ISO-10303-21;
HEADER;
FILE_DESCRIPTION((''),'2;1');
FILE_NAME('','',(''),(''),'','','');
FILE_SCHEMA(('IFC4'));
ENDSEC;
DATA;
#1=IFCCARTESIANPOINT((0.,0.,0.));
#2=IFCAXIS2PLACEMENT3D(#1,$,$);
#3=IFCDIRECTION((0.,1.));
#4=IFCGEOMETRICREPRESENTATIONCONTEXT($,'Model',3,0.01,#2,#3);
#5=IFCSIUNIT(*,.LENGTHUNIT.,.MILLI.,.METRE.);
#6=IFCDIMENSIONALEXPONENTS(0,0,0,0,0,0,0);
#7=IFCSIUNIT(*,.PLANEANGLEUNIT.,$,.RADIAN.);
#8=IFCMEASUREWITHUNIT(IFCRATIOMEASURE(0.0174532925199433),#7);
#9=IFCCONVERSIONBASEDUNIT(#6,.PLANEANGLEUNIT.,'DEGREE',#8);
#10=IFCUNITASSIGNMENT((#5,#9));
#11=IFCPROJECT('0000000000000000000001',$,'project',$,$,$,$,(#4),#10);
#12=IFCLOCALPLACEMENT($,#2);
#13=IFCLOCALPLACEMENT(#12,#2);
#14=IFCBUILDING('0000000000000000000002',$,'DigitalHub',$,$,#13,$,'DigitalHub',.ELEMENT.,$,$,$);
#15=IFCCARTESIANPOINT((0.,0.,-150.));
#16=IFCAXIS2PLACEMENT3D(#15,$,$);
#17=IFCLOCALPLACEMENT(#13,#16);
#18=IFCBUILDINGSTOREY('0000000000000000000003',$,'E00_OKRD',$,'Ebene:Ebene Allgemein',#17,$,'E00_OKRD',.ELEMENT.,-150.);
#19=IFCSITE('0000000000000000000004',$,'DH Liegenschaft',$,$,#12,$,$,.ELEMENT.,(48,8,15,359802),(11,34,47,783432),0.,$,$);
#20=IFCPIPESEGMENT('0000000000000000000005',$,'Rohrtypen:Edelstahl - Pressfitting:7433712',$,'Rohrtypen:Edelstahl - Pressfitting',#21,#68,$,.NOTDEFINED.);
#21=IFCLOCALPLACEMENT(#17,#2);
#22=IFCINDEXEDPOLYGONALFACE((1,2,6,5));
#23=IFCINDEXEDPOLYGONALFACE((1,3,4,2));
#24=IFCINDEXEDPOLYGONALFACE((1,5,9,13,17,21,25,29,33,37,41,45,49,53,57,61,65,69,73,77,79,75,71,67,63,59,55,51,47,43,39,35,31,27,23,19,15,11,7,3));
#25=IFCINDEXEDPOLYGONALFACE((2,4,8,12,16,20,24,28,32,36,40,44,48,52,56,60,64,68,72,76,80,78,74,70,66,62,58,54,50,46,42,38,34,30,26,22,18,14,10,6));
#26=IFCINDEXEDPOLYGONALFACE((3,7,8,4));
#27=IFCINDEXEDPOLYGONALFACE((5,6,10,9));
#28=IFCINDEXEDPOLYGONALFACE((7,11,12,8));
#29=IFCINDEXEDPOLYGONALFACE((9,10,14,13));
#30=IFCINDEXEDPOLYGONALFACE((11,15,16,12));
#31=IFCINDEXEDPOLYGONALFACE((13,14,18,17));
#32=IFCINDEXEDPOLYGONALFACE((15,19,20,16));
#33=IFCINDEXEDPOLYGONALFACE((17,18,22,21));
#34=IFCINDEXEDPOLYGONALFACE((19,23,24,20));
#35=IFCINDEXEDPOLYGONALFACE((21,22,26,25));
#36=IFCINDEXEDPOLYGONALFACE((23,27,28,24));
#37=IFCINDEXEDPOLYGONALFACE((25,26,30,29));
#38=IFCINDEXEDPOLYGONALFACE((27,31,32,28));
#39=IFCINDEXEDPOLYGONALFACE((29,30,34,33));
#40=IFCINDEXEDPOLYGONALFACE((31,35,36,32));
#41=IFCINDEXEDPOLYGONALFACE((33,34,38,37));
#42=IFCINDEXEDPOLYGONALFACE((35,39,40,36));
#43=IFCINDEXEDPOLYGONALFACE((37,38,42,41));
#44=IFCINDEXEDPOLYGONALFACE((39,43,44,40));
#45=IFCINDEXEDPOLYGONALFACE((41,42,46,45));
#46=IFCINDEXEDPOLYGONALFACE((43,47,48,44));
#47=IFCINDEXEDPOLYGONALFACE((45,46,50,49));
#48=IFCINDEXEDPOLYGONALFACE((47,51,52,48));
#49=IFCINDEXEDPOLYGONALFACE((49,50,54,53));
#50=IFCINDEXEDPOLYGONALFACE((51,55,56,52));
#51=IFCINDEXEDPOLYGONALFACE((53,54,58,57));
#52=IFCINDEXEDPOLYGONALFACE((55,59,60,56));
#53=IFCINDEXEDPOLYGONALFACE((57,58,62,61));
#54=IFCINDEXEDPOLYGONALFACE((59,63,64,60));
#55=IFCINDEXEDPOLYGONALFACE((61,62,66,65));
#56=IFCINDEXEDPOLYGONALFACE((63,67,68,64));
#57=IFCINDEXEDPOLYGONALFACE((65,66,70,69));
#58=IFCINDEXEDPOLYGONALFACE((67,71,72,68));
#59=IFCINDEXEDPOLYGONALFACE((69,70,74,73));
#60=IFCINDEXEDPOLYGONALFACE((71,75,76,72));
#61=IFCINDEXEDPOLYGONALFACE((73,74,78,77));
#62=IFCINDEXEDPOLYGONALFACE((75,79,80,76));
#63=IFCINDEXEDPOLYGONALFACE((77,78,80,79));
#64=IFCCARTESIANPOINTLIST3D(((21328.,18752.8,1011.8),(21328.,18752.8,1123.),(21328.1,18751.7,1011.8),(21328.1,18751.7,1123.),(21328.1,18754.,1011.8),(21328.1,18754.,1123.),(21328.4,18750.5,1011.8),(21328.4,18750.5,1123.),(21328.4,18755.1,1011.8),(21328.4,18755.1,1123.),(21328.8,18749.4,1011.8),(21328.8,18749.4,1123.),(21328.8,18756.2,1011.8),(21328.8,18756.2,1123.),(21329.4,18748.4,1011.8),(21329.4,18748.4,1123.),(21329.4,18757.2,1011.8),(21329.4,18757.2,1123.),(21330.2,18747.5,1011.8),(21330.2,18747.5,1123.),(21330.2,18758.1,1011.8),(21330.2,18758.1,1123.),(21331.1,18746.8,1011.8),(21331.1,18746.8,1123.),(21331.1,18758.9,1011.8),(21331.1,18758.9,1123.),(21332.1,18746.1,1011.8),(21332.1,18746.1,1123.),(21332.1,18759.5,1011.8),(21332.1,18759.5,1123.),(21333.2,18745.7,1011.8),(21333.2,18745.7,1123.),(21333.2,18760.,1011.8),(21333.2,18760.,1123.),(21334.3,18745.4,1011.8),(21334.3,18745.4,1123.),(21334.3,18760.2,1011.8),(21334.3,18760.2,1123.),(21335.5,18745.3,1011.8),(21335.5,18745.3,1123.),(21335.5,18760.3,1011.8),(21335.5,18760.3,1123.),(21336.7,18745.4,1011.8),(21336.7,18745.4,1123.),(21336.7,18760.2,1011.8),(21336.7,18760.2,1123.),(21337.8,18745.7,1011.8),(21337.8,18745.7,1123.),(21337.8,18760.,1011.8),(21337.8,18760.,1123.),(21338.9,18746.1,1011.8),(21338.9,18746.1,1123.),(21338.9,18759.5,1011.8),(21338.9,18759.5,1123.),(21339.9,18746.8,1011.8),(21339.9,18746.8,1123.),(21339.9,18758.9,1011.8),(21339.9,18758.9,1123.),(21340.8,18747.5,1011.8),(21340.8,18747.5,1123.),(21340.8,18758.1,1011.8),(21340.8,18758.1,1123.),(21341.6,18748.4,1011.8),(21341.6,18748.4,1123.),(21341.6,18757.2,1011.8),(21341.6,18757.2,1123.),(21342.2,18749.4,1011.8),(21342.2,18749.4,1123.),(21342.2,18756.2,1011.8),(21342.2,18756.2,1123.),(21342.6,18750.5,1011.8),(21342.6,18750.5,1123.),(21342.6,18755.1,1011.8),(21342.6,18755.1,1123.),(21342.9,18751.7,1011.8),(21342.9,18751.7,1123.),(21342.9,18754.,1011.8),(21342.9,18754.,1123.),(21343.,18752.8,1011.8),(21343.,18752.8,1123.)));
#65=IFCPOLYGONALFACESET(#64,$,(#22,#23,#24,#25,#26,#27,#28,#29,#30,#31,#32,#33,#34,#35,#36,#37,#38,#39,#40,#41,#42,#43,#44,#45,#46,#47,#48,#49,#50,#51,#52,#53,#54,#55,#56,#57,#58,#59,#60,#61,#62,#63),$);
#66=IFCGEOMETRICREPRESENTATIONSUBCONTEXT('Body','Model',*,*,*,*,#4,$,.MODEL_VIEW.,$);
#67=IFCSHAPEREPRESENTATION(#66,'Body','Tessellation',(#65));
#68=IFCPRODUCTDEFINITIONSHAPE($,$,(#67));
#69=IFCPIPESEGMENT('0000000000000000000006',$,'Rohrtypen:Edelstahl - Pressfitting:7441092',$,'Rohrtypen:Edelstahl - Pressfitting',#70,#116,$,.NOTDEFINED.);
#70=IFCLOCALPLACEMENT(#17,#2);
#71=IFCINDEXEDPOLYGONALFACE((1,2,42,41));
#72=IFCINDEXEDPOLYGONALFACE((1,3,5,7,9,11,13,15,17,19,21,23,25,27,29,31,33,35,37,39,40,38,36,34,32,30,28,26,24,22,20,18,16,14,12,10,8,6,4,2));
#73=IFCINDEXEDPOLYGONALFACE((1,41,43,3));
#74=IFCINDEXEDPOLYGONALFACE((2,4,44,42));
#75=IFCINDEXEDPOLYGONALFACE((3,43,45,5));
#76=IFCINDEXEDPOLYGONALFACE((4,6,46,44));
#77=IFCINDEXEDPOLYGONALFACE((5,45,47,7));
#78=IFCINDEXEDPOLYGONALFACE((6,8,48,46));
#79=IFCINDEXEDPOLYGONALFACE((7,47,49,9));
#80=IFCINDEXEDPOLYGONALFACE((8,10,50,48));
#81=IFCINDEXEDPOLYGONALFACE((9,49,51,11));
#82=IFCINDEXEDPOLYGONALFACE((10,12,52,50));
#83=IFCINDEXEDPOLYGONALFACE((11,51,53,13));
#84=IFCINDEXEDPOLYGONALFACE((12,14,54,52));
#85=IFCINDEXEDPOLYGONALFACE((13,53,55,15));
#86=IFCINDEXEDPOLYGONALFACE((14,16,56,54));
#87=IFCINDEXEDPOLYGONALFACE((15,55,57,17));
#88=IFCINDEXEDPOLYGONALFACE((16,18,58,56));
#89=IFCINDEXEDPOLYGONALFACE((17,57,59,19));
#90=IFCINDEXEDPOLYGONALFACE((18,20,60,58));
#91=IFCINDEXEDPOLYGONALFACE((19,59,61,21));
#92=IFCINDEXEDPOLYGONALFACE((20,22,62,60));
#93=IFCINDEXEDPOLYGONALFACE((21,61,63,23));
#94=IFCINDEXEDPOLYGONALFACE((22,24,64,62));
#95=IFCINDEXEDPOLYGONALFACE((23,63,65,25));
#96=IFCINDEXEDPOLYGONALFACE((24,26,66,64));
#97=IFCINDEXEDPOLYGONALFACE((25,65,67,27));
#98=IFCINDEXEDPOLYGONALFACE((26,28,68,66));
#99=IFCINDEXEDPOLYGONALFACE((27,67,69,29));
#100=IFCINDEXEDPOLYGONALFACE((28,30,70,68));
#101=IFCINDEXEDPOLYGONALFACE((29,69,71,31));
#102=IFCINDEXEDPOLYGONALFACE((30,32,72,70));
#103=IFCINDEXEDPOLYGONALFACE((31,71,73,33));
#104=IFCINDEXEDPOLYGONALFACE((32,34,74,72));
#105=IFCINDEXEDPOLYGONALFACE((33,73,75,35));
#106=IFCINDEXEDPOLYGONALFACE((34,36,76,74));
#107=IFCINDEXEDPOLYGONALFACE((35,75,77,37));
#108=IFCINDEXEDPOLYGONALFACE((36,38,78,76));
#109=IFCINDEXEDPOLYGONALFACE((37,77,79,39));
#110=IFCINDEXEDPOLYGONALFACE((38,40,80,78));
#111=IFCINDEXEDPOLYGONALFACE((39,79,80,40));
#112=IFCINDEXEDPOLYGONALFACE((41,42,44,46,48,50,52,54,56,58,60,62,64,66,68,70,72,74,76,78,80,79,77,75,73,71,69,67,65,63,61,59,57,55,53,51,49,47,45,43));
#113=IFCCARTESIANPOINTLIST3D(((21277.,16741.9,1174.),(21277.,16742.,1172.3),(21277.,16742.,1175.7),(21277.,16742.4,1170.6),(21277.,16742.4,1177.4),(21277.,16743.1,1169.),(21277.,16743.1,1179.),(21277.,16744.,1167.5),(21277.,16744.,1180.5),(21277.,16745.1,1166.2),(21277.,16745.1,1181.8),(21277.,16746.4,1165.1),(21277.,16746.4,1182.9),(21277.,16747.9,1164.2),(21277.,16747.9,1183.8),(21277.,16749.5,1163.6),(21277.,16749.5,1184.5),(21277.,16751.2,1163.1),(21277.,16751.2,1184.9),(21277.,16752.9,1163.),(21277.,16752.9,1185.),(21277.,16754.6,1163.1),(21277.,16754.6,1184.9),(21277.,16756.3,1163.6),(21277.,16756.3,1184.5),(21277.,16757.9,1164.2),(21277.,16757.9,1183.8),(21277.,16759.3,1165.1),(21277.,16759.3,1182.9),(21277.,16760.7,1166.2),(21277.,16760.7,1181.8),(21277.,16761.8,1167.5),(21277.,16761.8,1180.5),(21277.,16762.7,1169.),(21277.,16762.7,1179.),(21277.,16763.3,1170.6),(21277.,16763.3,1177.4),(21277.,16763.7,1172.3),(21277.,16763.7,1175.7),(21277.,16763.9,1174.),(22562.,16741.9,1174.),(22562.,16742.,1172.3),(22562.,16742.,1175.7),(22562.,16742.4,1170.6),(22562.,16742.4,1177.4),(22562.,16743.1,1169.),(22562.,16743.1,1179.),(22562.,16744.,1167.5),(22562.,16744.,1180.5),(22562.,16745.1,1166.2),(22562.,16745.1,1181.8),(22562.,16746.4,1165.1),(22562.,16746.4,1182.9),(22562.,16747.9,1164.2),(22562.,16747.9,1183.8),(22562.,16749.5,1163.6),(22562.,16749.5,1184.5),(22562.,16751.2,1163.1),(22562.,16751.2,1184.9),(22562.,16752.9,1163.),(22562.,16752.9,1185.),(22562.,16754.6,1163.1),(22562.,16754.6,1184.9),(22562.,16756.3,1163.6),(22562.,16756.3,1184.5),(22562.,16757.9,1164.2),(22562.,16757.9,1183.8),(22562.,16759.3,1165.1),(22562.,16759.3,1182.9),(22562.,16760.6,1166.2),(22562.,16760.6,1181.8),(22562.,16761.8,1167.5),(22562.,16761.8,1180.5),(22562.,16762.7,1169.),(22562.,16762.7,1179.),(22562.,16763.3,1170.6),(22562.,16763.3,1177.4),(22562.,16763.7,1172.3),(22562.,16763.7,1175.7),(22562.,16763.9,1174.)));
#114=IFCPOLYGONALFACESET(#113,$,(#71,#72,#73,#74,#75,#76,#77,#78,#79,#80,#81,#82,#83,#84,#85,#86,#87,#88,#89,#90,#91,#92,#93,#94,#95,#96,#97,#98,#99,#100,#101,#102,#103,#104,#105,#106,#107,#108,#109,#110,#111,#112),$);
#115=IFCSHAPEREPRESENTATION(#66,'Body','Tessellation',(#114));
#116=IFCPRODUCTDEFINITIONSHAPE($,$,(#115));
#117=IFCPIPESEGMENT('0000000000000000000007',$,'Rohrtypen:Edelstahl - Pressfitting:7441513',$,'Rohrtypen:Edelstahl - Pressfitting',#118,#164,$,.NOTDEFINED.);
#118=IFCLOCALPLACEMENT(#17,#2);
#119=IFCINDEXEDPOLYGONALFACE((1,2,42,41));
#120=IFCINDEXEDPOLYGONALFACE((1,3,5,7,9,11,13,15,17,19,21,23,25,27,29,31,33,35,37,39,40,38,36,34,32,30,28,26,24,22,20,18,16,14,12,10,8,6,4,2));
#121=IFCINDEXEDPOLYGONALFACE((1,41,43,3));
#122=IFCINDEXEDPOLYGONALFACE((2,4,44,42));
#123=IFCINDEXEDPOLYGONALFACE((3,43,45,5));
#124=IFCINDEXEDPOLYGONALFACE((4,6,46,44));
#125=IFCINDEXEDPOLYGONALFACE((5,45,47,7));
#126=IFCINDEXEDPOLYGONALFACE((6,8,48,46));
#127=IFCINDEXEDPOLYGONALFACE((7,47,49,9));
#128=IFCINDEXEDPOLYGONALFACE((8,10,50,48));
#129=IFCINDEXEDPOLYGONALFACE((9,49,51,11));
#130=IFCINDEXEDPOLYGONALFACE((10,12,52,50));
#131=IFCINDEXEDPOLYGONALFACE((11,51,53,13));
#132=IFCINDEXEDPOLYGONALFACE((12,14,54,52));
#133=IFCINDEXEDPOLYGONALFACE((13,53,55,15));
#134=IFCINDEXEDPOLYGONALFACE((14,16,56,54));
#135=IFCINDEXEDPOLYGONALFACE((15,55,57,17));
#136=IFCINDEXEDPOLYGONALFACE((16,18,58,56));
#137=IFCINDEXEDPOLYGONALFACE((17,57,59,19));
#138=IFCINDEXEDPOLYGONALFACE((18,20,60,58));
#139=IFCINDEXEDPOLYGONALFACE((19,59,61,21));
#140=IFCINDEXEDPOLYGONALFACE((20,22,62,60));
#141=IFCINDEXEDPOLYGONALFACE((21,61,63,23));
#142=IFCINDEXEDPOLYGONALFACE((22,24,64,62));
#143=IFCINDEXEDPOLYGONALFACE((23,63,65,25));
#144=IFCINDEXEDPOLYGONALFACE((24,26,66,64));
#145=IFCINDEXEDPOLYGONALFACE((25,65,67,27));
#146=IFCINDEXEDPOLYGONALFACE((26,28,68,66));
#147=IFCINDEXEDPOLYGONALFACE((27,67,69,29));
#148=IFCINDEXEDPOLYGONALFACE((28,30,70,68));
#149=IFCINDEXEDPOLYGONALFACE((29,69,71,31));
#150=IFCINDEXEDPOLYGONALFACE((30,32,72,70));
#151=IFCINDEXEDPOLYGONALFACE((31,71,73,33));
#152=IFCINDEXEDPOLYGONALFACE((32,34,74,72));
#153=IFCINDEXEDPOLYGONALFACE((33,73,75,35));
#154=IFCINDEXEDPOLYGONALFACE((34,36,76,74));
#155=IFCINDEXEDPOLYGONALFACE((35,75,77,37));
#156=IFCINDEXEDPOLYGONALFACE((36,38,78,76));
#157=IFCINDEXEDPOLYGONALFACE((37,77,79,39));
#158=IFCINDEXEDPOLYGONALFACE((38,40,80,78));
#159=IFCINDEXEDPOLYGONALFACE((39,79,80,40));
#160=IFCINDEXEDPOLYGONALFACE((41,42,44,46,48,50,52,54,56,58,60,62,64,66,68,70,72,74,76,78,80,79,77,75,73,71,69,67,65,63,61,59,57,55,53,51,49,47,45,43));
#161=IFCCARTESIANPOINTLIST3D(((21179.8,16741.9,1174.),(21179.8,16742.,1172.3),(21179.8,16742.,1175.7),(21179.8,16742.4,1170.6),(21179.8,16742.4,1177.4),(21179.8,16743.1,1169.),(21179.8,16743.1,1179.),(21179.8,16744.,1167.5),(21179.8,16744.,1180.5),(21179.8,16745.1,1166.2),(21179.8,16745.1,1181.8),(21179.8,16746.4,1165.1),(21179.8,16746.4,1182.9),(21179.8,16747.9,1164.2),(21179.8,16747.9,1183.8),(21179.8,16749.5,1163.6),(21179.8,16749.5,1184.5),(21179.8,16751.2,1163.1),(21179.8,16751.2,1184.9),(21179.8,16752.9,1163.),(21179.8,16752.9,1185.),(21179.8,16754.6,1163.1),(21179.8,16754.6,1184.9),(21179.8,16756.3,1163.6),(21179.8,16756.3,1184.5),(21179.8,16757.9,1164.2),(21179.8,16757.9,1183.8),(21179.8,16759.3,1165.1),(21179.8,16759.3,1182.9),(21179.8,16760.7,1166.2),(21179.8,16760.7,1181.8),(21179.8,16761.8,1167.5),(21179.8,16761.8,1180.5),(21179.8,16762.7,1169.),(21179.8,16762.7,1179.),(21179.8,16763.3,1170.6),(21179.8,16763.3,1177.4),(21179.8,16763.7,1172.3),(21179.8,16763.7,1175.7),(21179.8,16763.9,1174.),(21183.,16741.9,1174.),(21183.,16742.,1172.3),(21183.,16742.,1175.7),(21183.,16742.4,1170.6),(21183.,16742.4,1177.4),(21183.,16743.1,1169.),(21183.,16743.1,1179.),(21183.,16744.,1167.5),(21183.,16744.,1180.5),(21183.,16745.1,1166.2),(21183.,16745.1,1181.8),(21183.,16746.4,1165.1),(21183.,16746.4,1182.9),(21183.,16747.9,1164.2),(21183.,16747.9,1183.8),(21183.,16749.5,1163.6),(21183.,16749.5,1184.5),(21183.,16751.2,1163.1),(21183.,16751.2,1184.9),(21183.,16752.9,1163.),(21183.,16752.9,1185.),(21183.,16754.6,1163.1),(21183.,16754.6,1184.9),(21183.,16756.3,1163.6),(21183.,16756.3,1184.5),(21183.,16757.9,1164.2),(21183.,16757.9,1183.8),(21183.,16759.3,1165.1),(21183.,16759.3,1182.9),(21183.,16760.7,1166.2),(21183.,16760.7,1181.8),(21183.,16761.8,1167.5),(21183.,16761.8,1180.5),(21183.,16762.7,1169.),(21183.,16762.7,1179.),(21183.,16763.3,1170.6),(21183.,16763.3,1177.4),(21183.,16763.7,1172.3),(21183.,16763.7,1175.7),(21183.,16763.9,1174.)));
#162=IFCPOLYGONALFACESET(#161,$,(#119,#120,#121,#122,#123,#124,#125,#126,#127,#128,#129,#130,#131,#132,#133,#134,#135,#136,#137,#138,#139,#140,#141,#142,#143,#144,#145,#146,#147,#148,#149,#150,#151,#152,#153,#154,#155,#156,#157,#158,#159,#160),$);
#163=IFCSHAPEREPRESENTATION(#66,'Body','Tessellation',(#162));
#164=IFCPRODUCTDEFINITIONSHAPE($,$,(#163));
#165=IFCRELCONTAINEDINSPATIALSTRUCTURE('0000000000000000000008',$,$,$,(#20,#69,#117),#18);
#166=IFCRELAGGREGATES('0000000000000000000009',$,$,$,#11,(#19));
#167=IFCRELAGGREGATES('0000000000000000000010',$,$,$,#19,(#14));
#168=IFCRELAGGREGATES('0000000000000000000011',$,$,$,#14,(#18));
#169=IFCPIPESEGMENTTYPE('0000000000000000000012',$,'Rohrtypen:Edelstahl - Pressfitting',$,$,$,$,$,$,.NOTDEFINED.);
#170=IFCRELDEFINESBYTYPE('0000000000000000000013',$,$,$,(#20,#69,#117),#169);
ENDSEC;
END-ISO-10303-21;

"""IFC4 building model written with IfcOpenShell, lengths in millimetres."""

from ifc_helpers import new_model, entity, si_unit, converted_unit, direction, frame, origin, place, context, subcontext, project, spatial, indexed_curve, outline, extrude, type_object, element, save


model = new_model("IFC4")

# Units and contexts
model_context = context("Model", 3, precision=0.01, world=origin(), true_north=direction((0.0, 1.0)))
body_context = subcontext(model_context, "Body", "Model", "MODEL_VIEW")
ifc_project = project(units=[si_unit("LENGTHUNIT", "METRE", prefix="MILLI"), converted_unit("PLANEANGLEUNIT", "DEGREE", entity("IfcRatioMeasure", 0.0174532925199433), si_unit("PLANEANGLEUNIT", "RADIAN"), dimensions=[0, 0, 0, 0, 0, 0, 0])], contexts=[model_context])

# Site, building, storey
site_placement = place(None, origin())
site = spatial("IfcSite", under=ifc_project, at=site_placement, Name="DH Liegenschaft", CompositionType="ELEMENT", RefLatitude=(48, 8, 15, 359802), RefLongitude=(11, 34, 47, 783432), RefElevation=0.0)
building_placement = place(site_placement, origin())
building = spatial("IfcBuilding", under=site, at=building_placement, Name="DigitalHub", LongName="DigitalHub", CompositionType="ELEMENT")
storey_placement = place(building_placement, frame((0.0, 0.0, -150.0)))
storey = spatial("IfcBuildingStorey", under=building, at=storey_placement, Name="E00_OKRD", ObjectType="Ebene:Ebene Allgemein", LongName="E00_OKRD", CompositionType="ELEMENT", Elevation=-150.0)

# Pipe segments
pipe_segment_type_1 = type_object("IfcPipeSegmentType", Name="Rohrtypen:Edelstahl - Pressfitting", PredefinedType="NOTDEFINED")
pipe_segment_1_placement = place(storey_placement, frame((21326.4, 18743.7, 1011.8)))
element("IfcPipeSegment", 1, at=pipe_segment_1_placement, inside=storey, type_object=pipe_segment_type_1, Name="Rohrtypen:Edelstahl - Pressfitting:7433712", ObjectType="Rohrtypen:Edelstahl - Pressfitting", PredefinedType="NOTDEFINED", context=body_context, shape_type="SweptSolid", body=[
    extrude(outline(indexed_curve([(7.5, 0.0), (7.4, 1.2), (7.1, 2.3), (6.7, 3.4), (6.1, 4.4), (5.3, 5.3), (4.4, 6.1), (3.4, 6.7), (2.3, 7.1), (1.2, 7.4), (0.0, 7.5), (-1.2, 7.4), (-2.3, 7.1), (-3.4, 6.7), (-4.4, 6.1), (-5.3, 5.3), (-6.1, 4.4), (-6.7, 3.4), (-7.1, 2.3), (-7.4, 1.2), (-7.5, 0.0), (-7.4, -1.2), (-7.1, -2.3), (-6.7, -3.4), (-6.1, -4.4), (-5.3, -5.3), (-4.4, -6.1), (-3.4, -6.7), (-2.3, -7.1), (-1.2, -7.4), (0.0, -7.5), (1.2, -7.4), (2.3, -7.1), (3.4, -6.7), (4.4, -6.1), (5.3, -5.3), (6.1, -4.4), (6.7, -3.4), (7.1, -2.3), (7.4, -1.2), (7.5, 0.0)], self_intersect=False)), frame((9.1, 9.1, 0.0), z_axis=(-0.000002, 0.0, 1.0), x_axis=(-1.0, 0.0, -0.000002)), (0.0, 0.0, 1.0), 111.2),
])
pipe_segment_2_placement = place(storey_placement, frame((21277.0, 16740.3, 1161.4)))
element("IfcPipeSegment", 2, at=pipe_segment_2_placement, inside=storey, type_object=pipe_segment_type_1, Name="Rohrtypen:Edelstahl - Pressfitting:7441092", ObjectType="Rohrtypen:Edelstahl - Pressfitting", PredefinedType="NOTDEFINED", context=body_context, shape_type="SweptSolid", body=[
    extrude(outline(indexed_curve([(11.0, 0.0), (10.9, 1.7), (10.5, 3.4), (9.8, 5.0), (8.9, 6.5), (7.8, 7.8), (6.5, 8.9), (5.0, 9.8), (3.4, 10.5), (1.7, 10.9), (0.0, 11.0), (-1.7, 10.9), (-3.4, 10.5), (-5.0, 9.8), (-6.5, 8.9), (-7.8, 7.8), (-8.9, 6.5), (-9.8, 5.0), (-10.5, 3.4), (-10.9, 1.7), (-11.0, 0.0), (-10.9, -1.7), (-10.5, -3.4), (-9.8, -5.0), (-8.9, -6.5), (-7.8, -7.8), (-6.5, -8.9), (-5.0, -9.8), (-3.4, -10.5), (-1.7, -10.9), (0.0, -11.0), (1.7, -10.9), (3.4, -10.5), (5.0, -9.8), (6.5, -8.9), (7.8, -7.8), (8.9, -6.5), (9.8, -5.0), (10.5, -3.4), (10.9, -1.7), (11.0, 0.0)], self_intersect=False)), frame((0.0, 12.6, 12.6), z_axis=(1.0, -0.000001, 0.0), x_axis=(-0.000001, -1.0, 0.0)), (0.0, 0.0, 1.0), 1285.0),
])
pipe_segment_3_placement = place(storey_placement, frame((21179.8, 16740.3, 1161.4)))
element("IfcPipeSegment", 3, at=pipe_segment_3_placement, inside=storey, type_object=pipe_segment_type_1, Name="Rohrtypen:Edelstahl - Pressfitting:7441513", ObjectType="Rohrtypen:Edelstahl - Pressfitting", PredefinedType="NOTDEFINED", context=body_context, shape_type="SweptSolid", body=[
    extrude(outline(indexed_curve([(11.0, 0.0), (10.9, 1.7), (10.5, 3.4), (9.8, 5.0), (8.9, 6.5), (7.8, 7.8), (6.5, 8.9), (5.0, 9.8), (3.4, 10.5), (1.7, 10.9), (0.0, 11.0), (-1.7, 10.9), (-3.4, 10.5), (-5.0, 9.8), (-6.5, 8.9), (-7.8, 7.8), (-8.9, 6.5), (-9.8, 5.0), (-10.5, 3.4), (-10.9, 1.7), (-11.0, 0.0), (-10.9, -1.7), (-10.5, -3.4), (-9.8, -5.0), (-8.9, -6.5), (-7.8, -7.8), (-6.5, -8.9), (-5.0, -9.8), (-3.4, -10.5), (-1.7, -10.9), (0.0, -11.0), (1.7, -10.9), (3.4, -10.5), (5.0, -9.8), (6.5, -8.9), (7.8, -7.8), (8.9, -6.5), (9.8, -5.0), (10.5, -3.4), (10.9, -1.7), (11.0, 0.0)], self_intersect=False)), frame((0.0, 12.6, 12.6), z_axis=(1.0, -0.000027, 0.0), x_axis=(-0.000027, -1.0, 0.0)), (0.0, 0.0, 1.0), 3.2),
])

save(model, "model.ifc")
